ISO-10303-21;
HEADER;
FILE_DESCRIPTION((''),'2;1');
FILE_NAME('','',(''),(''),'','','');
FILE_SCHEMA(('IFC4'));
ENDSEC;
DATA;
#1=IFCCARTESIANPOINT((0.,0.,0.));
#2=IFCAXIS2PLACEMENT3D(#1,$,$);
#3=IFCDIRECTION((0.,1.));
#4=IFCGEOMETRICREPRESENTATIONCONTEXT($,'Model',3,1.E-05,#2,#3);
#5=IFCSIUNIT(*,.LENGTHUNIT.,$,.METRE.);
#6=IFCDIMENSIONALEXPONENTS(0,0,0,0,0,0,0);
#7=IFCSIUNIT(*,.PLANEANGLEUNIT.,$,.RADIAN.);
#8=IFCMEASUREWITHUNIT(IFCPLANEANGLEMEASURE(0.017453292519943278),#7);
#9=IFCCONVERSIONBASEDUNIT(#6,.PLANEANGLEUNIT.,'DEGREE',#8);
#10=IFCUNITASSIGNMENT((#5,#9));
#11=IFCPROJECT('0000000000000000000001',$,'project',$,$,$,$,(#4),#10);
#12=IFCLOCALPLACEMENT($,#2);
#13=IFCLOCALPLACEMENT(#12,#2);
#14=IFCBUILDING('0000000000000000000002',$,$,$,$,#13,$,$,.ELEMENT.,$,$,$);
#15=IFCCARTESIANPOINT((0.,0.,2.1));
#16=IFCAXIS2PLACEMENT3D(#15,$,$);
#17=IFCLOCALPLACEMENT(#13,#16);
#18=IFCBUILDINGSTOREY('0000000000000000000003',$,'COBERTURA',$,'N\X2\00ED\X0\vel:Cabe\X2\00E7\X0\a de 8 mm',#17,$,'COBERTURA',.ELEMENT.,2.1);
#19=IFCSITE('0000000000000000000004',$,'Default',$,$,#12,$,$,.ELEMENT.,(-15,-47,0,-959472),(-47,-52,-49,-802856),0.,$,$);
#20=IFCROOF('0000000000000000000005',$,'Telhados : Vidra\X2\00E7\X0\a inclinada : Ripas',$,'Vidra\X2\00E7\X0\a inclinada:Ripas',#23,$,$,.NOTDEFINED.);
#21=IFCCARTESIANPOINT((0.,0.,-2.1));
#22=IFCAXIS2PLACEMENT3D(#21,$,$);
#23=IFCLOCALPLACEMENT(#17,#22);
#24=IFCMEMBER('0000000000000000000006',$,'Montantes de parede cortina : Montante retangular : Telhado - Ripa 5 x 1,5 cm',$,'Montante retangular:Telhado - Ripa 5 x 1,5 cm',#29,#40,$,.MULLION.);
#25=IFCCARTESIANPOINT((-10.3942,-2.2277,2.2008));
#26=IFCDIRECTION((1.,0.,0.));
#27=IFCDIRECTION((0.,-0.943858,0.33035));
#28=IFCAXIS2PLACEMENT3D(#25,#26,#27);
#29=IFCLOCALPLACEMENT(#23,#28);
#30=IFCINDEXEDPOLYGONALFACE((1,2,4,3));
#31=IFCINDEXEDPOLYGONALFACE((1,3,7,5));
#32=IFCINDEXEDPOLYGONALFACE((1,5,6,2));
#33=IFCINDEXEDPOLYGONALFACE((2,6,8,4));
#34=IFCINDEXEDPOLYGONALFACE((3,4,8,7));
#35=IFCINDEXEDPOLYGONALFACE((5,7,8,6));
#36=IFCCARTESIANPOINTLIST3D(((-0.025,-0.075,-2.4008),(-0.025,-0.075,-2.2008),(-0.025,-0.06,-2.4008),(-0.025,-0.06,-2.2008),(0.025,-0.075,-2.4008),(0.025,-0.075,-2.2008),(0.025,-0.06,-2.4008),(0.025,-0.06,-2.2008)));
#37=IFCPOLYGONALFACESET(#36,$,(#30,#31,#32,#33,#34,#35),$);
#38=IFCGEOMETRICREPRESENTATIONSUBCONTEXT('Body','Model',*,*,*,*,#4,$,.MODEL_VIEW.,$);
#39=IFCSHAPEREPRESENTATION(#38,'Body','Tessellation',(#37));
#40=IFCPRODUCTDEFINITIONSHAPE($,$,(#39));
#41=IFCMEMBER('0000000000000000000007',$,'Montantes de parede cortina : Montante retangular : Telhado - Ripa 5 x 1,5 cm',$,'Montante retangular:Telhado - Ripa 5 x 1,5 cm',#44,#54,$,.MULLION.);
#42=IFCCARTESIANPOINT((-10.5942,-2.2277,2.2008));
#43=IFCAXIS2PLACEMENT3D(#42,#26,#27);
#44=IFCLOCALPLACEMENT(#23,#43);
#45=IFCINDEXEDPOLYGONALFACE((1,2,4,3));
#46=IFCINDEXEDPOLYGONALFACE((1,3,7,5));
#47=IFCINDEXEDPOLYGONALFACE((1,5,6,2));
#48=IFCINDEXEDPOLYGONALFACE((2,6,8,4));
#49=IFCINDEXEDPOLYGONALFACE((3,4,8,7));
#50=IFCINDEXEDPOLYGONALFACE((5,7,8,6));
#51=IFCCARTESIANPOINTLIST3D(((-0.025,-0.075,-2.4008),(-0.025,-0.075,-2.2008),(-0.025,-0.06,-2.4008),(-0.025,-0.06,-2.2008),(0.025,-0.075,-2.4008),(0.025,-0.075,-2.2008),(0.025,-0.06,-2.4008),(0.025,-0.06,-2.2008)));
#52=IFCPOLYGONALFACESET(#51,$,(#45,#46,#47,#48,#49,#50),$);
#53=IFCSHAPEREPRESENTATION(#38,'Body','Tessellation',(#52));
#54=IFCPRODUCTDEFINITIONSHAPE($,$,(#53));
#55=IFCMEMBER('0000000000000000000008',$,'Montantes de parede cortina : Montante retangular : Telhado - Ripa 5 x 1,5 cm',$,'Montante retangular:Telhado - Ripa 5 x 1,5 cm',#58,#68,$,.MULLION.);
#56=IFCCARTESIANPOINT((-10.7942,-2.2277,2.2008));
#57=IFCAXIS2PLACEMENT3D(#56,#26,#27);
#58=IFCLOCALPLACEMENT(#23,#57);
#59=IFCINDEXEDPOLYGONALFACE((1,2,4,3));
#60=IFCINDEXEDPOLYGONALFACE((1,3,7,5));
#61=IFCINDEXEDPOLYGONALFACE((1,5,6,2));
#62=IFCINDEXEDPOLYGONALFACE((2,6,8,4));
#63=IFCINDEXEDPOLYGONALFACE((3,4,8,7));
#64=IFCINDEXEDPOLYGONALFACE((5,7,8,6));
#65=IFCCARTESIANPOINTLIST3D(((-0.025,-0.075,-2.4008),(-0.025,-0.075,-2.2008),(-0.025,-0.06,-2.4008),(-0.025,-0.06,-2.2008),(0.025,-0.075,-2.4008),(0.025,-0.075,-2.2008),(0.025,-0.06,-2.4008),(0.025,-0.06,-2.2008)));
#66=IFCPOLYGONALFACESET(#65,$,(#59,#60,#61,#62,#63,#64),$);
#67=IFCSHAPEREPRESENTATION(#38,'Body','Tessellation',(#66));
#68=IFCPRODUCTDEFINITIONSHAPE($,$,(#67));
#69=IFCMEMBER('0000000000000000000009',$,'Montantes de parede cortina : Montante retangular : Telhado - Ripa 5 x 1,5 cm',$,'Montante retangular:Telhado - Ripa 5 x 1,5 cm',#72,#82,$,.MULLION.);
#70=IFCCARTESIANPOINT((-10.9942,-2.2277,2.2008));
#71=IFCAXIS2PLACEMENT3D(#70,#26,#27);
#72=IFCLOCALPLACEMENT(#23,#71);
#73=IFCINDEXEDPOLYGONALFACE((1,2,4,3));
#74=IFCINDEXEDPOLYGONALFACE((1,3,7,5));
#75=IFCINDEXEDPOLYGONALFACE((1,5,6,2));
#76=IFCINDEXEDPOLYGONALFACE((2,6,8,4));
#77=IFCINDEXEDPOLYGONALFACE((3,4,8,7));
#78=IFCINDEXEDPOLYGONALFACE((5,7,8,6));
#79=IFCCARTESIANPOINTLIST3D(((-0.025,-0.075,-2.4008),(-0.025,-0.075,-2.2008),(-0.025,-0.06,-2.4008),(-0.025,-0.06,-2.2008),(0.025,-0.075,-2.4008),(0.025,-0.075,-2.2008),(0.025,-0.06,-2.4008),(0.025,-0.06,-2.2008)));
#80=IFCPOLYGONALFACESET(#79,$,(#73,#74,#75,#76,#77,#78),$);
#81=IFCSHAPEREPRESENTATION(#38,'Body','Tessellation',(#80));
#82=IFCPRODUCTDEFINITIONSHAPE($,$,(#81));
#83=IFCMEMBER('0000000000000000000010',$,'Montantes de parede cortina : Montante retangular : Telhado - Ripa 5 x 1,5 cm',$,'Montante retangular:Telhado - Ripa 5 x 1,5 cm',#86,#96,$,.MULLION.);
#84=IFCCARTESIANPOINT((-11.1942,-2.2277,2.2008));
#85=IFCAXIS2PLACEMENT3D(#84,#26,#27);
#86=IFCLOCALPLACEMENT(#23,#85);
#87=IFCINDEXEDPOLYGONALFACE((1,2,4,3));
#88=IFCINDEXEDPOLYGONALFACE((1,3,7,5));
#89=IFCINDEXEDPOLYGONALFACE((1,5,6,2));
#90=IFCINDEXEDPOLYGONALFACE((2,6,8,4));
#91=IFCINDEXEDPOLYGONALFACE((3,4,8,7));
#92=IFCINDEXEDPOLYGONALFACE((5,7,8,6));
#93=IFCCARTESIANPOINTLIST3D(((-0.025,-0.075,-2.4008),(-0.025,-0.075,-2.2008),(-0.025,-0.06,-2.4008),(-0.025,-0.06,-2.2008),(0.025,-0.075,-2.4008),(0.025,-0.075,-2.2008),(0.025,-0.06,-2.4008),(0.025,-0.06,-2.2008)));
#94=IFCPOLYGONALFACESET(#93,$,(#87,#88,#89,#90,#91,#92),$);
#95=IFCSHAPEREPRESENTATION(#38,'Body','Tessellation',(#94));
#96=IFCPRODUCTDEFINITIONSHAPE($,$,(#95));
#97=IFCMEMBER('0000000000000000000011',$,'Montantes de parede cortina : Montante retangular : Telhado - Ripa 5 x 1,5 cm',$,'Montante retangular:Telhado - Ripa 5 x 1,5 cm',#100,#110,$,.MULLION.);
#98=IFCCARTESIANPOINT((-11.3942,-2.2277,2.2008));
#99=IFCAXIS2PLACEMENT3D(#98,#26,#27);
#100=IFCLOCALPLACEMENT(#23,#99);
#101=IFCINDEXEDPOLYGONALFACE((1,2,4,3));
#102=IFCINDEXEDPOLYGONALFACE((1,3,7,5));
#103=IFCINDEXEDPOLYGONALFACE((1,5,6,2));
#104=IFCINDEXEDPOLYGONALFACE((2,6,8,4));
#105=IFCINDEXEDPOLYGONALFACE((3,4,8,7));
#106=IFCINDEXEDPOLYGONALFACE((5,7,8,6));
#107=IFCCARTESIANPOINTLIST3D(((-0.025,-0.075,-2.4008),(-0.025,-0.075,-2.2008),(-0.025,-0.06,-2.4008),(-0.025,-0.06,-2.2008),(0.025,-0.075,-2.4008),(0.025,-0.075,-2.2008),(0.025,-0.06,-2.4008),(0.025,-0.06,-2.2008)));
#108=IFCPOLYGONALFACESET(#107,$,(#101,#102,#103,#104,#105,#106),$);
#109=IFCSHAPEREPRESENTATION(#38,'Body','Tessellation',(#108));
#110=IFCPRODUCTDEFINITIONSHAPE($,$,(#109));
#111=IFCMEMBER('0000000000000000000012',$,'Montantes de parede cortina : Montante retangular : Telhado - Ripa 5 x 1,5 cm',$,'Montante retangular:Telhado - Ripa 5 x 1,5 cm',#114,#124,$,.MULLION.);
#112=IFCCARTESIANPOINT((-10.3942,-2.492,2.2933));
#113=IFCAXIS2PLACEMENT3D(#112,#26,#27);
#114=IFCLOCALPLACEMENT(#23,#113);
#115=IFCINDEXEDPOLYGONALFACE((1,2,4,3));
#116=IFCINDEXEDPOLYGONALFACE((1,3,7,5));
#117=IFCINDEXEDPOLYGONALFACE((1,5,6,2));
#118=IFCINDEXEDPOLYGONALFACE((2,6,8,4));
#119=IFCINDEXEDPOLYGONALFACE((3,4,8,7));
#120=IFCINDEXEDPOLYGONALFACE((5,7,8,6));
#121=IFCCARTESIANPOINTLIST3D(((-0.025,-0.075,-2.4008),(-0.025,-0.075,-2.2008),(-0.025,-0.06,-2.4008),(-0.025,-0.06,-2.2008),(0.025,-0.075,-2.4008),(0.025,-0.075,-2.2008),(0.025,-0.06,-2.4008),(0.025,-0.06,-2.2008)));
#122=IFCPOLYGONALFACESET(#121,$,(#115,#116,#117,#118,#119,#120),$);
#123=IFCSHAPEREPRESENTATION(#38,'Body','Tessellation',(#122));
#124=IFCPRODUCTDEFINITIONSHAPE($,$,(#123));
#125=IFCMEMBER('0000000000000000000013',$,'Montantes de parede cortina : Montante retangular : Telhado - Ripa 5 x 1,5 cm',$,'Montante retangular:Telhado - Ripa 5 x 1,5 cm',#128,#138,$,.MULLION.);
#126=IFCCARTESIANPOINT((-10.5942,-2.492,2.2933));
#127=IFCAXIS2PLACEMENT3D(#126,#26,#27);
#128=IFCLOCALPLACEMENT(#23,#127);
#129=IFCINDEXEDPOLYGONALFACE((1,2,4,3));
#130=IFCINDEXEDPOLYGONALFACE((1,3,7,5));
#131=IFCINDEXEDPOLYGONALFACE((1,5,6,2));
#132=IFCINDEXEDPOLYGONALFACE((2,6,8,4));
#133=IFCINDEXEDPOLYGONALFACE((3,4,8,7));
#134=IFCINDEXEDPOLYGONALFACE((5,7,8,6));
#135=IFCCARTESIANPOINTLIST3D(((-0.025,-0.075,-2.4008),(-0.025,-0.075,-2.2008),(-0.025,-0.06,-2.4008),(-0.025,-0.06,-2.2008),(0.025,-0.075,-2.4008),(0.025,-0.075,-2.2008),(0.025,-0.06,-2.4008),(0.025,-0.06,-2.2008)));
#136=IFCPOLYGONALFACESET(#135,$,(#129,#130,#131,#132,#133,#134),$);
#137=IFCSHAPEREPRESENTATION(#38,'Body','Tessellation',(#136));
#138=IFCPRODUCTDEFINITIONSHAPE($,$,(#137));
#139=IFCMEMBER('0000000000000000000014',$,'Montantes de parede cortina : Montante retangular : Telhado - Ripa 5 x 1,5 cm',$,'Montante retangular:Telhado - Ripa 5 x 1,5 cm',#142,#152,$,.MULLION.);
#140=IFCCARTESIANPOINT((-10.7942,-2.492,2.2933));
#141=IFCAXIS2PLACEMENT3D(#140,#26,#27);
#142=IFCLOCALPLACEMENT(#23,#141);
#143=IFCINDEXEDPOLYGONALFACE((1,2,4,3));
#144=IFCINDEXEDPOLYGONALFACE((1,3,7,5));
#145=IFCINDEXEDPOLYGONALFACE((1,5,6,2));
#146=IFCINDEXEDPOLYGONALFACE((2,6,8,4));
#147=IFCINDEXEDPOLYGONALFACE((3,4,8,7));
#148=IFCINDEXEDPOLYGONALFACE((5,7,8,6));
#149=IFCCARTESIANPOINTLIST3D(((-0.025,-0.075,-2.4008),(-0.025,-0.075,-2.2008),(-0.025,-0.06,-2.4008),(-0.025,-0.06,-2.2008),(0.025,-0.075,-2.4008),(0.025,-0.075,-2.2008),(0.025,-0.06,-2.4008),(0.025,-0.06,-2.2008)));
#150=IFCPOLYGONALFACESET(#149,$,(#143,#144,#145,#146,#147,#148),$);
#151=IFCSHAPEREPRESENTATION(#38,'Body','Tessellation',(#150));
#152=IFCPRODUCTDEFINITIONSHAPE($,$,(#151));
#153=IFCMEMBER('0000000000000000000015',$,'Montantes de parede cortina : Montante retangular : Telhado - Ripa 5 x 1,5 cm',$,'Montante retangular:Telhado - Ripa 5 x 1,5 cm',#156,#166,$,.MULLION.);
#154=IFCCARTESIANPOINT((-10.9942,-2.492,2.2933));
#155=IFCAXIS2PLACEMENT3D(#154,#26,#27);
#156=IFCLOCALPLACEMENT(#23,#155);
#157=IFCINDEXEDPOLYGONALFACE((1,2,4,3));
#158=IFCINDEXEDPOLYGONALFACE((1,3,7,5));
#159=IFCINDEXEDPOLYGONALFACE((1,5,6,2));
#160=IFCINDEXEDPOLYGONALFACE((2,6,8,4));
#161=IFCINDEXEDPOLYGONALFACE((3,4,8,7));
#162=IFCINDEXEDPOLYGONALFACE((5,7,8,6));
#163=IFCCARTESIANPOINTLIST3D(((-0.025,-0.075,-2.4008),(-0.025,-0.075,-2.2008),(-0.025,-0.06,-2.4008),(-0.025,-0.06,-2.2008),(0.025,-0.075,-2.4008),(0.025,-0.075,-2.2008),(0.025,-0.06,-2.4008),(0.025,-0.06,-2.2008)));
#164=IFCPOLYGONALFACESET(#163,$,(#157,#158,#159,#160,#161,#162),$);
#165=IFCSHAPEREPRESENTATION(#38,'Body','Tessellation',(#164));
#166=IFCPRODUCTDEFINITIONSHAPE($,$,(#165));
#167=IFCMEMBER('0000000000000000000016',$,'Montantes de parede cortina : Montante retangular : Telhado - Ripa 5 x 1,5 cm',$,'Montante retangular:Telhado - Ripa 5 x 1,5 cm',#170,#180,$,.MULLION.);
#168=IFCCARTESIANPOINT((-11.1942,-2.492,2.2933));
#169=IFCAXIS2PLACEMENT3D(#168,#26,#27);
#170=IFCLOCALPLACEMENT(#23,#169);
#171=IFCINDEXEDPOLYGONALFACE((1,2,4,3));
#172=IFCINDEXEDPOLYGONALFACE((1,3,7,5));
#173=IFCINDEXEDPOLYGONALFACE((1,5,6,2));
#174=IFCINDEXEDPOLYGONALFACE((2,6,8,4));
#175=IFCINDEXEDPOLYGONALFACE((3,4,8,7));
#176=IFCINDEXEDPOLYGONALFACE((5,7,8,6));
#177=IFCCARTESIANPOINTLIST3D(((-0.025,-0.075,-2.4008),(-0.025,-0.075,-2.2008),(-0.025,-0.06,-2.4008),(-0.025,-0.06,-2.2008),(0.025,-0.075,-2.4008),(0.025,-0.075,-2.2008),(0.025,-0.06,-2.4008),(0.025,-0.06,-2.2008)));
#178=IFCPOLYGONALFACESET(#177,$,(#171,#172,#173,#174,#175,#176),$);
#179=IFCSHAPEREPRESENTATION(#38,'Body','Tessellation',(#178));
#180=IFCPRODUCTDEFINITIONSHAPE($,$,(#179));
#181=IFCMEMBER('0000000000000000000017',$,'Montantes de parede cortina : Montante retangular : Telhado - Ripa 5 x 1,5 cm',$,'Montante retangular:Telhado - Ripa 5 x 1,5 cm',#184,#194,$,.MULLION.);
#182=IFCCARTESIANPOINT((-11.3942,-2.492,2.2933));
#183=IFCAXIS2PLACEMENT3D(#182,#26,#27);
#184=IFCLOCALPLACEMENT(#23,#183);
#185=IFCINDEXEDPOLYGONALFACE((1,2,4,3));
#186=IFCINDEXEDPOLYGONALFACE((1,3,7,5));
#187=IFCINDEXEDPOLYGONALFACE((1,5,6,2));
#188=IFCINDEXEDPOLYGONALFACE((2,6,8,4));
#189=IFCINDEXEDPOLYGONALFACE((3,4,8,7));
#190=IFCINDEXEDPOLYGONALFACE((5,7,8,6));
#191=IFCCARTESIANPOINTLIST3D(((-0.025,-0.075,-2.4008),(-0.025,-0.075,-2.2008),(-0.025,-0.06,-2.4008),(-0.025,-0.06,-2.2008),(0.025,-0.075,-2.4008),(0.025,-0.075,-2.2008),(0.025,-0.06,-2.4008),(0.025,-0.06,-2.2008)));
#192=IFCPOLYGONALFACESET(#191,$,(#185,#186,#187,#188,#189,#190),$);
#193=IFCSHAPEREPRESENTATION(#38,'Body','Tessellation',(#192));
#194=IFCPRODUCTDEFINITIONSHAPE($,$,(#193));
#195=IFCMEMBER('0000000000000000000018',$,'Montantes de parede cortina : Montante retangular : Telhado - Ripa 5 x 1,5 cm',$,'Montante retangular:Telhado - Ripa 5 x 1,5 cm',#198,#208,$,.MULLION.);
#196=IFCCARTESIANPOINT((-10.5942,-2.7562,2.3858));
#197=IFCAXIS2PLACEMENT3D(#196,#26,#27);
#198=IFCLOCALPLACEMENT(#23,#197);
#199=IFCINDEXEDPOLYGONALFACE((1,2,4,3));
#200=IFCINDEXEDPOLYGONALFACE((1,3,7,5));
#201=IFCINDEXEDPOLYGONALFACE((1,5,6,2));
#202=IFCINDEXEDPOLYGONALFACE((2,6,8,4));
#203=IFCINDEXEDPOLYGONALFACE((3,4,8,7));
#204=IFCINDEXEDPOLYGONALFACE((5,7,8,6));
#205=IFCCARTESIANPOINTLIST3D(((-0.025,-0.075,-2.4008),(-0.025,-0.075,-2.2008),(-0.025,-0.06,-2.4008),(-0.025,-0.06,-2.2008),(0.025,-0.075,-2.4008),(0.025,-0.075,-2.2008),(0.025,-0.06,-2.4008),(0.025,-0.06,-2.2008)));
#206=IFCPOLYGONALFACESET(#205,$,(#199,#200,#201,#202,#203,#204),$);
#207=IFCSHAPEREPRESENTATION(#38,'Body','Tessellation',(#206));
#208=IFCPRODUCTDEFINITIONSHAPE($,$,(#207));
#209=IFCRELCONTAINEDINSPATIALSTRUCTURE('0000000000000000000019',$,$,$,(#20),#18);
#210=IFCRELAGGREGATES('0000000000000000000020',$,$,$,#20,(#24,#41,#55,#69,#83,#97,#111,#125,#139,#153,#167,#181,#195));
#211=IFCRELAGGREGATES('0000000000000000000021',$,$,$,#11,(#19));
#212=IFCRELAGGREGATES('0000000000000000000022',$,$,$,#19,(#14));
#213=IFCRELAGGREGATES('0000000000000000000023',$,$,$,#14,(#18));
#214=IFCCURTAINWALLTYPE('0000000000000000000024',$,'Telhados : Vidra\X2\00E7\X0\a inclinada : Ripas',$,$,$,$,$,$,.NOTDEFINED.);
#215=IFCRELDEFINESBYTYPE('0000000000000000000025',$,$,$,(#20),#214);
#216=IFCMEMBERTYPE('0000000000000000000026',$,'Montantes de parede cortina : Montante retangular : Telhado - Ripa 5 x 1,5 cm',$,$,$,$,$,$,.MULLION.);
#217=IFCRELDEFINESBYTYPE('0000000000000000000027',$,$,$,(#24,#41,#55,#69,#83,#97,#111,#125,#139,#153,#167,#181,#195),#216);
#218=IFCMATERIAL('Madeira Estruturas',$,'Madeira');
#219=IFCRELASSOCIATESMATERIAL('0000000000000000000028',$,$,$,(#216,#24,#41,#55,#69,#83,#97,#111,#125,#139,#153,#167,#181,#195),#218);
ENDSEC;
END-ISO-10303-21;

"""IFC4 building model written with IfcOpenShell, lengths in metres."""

from ifc_helpers import new_model, entity, si_unit, converted_unit, direction, frame, origin, place, context, subcontext, project, spatial, indexed_curve, outline, extrude, source, transform, mapped, material, type_object, type_shapes, element, aggregate, save


model = new_model("IFC4")

# Units and contexts
model_context = context("Model", 3, precision=1e-05, world=origin(), true_north=direction((0.0, 1.0)))
body_context = subcontext(model_context, "Body", "Model", "MODEL_VIEW")
ifc_project = project(units=[si_unit("LENGTHUNIT", "METRE"), converted_unit("PLANEANGLEUNIT", "DEGREE", entity("IfcPlaneAngleMeasure", 0.017453292519943278), si_unit("PLANEANGLEUNIT", "RADIAN"), dimensions=[0, 0, 0, 0, 0, 0, 0])], contexts=[model_context])

# Site, building, storey
site_placement = place(None, origin())
site = spatial("IfcSite", under=ifc_project, at=site_placement, Name="Default", CompositionType="ELEMENT", RefLatitude=(-15, -47, 0, -959472), RefLongitude=(-47, -52, -49, -802856), RefElevation=0.0)
building_placement = place(site_placement, origin())
building = spatial("IfcBuilding", under=site, at=building_placement, CompositionType="ELEMENT")
storey_placement = place(building_placement, frame((0.0, 0.0, 2.1)))
storey = spatial("IfcBuildingStorey", under=building, at=storey_placement, Name="COBERTURA", ObjectType="Nível:Cabeça de 8 mm", LongName="COBERTURA", CompositionType="ELEMENT", Elevation=2.1)

# Roof, members
curtain_wall_type = type_object("IfcCurtainWallType", Name="Telhados : Vidraça inclinada : Ripas", PredefinedType="NOTDEFINED")
roof_placement = place(storey_placement, frame((0.0, 0.0, -2.1)))
roof = element("IfcRoof", 1, at=roof_placement, inside=storey, type_object=curtain_wall_type, Name="Telhados : Vidraça inclinada : Ripas", ObjectType="Vidraça inclinada:Ripas", PredefinedType="NOTDEFINED")
ifc_material = material(Name="Madeira Estruturas", Category="Madeira")
member_type = type_object("IfcMemberType", Name="Montantes de parede cortina : Montante retangular : Telhado - Ripa 5 x 1,5 cm", PredefinedType="MULLION", material=ifc_material)
shared_shape = source(origin(), body_context, "Body", "SweptSolid", [
    extrude(outline(indexed_curve([(-0.025, -0.0075), (0.025, -0.0075), (0.025, 0.0075), (-0.025, 0.0075), (-0.025, -0.0075)], self_intersect=False)), frame((0.0, -0.0675, -2.4008), z_axis=(0.0, 0.0, 1.0), x_axis=(-1.0, 0.0, 0.0)), (0.0, 0.0, 1.0), 0.2),
])
type_shapes(member_type, [shared_shape])
member_1_placement = place(roof_placement, frame((-10.3942, -2.2277, 2.2008), z_axis=(1.0, 0.0, 0.0), x_axis=(0.0, -0.943858, 0.33035)))
member_1 = element("IfcMember", 2, at=member_1_placement, type_object=member_type, material=ifc_material, Name="Montantes de parede cortina : Montante retangular : Telhado - Ripa 5 x 1,5 cm", ObjectType="Montante retangular:Telhado - Ripa 5 x 1,5 cm", PredefinedType="MULLION", context=body_context, shape_type="MappedRepresentation", body=[
    mapped(shared_shape, transform((0.0, 0.0, 0.0), scale=1.0)),
])
member_2_placement = place(roof_placement, frame((-10.5942, -2.2277, 2.2008), z_axis=(1.0, 0.0, 0.0), x_axis=(0.0, -0.943858, 0.33035)))
member_2 = element("IfcMember", 3, at=member_2_placement, type_object=member_type, material=ifc_material, Name="Montantes de parede cortina : Montante retangular : Telhado - Ripa 5 x 1,5 cm", ObjectType="Montante retangular:Telhado - Ripa 5 x 1,5 cm", PredefinedType="MULLION", context=body_context, shape_type="MappedRepresentation", body=[
    mapped(shared_shape, transform((0.0, 0.0, 0.0), scale=1.0)),
])
member_3_placement = place(roof_placement, frame((-10.7942, -2.2277, 2.2008), z_axis=(1.0, 0.0, 0.0), x_axis=(0.0, -0.943858, 0.33035)))
member_3 = element("IfcMember", 4, at=member_3_placement, type_object=member_type, material=ifc_material, Name="Montantes de parede cortina : Montante retangular : Telhado - Ripa 5 x 1,5 cm", ObjectType="Montante retangular:Telhado - Ripa 5 x 1,5 cm", PredefinedType="MULLION", context=body_context, shape_type="MappedRepresentation", body=[
    mapped(shared_shape, transform((0.0, 0.0, 0.0), scale=1.0)),
])
member_4_placement = place(roof_placement, frame((-10.9942, -2.2277, 2.2008), z_axis=(1.0, 0.0, 0.0), x_axis=(0.0, -0.943858, 0.33035)))
member_4 = element("IfcMember", 5, at=member_4_placement, type_object=member_type, material=ifc_material, Name="Montantes de parede cortina : Montante retangular : Telhado - Ripa 5 x 1,5 cm", ObjectType="Montante retangular:Telhado - Ripa 5 x 1,5 cm", PredefinedType="MULLION", context=body_context, shape_type="MappedRepresentation", body=[
    mapped(shared_shape, transform((0.0, 0.0, 0.0), scale=1.0)),
])
member_5_placement = place(roof_placement, frame((-11.1942, -2.2277, 2.2008), z_axis=(1.0, 0.0, 0.0), x_axis=(0.0, -0.943858, 0.33035)))
member_5 = element("IfcMember", 6, at=member_5_placement, type_object=member_type, material=ifc_material, Name="Montantes de parede cortina : Montante retangular : Telhado - Ripa 5 x 1,5 cm", ObjectType="Montante retangular:Telhado - Ripa 5 x 1,5 cm", PredefinedType="MULLION", context=body_context, shape_type="MappedRepresentation", body=[
    mapped(shared_shape, transform((0.0, 0.0, 0.0), scale=1.0)),
])
member_6_placement = place(roof_placement, frame((-11.3942, -2.2277, 2.2008), z_axis=(1.0, 0.0, 0.0), x_axis=(0.0, -0.943858, 0.33035)))
member_6 = element("IfcMember", 7, at=member_6_placement, type_object=member_type, material=ifc_material, Name="Montantes de parede cortina : Montante retangular : Telhado - Ripa 5 x 1,5 cm", ObjectType="Montante retangular:Telhado - Ripa 5 x 1,5 cm", PredefinedType="MULLION", context=body_context, shape_type="MappedRepresentation", body=[
    mapped(shared_shape, transform((0.0, 0.0, 0.0), scale=1.0)),
])
member_7_placement = place(roof_placement, frame((-10.3942, -2.492, 2.2933), z_axis=(1.0, 0.0, 0.0), x_axis=(0.0, -0.943858, 0.33035)))
member_7 = element("IfcMember", 8, at=member_7_placement, type_object=member_type, material=ifc_material, Name="Montantes de parede cortina : Montante retangular : Telhado - Ripa 5 x 1,5 cm", ObjectType="Montante retangular:Telhado - Ripa 5 x 1,5 cm", PredefinedType="MULLION", context=body_context, shape_type="MappedRepresentation", body=[
    mapped(shared_shape, transform((0.0, 0.0, 0.0), scale=1.0)),
])
member_8_placement = place(roof_placement, frame((-10.5942, -2.492, 2.2933), z_axis=(1.0, 0.0, 0.0), x_axis=(0.0, -0.943858, 0.33035)))
member_8 = element("IfcMember", 9, at=member_8_placement, type_object=member_type, material=ifc_material, Name="Montantes de parede cortina : Montante retangular : Telhado - Ripa 5 x 1,5 cm", ObjectType="Montante retangular:Telhado - Ripa 5 x 1,5 cm", PredefinedType="MULLION", context=body_context, shape_type="MappedRepresentation", body=[
    mapped(shared_shape, transform((0.0, 0.0, 0.0), scale=1.0)),
])
member_9_placement = place(roof_placement, frame((-10.7942, -2.492, 2.2933), z_axis=(1.0, 0.0, 0.0), x_axis=(0.0, -0.943858, 0.33035)))
member_9 = element("IfcMember", 10, at=member_9_placement, type_object=member_type, material=ifc_material, Name="Montantes de parede cortina : Montante retangular : Telhado - Ripa 5 x 1,5 cm", ObjectType="Montante retangular:Telhado - Ripa 5 x 1,5 cm", PredefinedType="MULLION", context=body_context, shape_type="MappedRepresentation", body=[
    mapped(shared_shape, transform((0.0, 0.0, 0.0), scale=1.0)),
])
member_10_placement = place(roof_placement, frame((-10.9942, -2.492, 2.2933), z_axis=(1.0, 0.0, 0.0), x_axis=(0.0, -0.943858, 0.33035)))
member_10 = element("IfcMember", 11, at=member_10_placement, type_object=member_type, material=ifc_material, Name="Montantes de parede cortina : Montante retangular : Telhado - Ripa 5 x 1,5 cm", ObjectType="Montante retangular:Telhado - Ripa 5 x 1,5 cm", PredefinedType="MULLION", context=body_context, shape_type="MappedRepresentation", body=[
    mapped(shared_shape, transform((0.0, 0.0, 0.0), scale=1.0)),
])
member_11_placement = place(roof_placement, frame((-11.1942, -2.492, 2.2933), z_axis=(1.0, 0.0, 0.0), x_axis=(0.0, -0.943858, 0.33035)))
member_11 = element("IfcMember", 12, at=member_11_placement, type_object=member_type, material=ifc_material, Name="Montantes de parede cortina : Montante retangular : Telhado - Ripa 5 x 1,5 cm", ObjectType="Montante retangular:Telhado - Ripa 5 x 1,5 cm", PredefinedType="MULLION", context=body_context, shape_type="MappedRepresentation", body=[
    mapped(shared_shape, transform((0.0, 0.0, 0.0), scale=1.0)),
])
member_12_placement = place(roof_placement, frame((-11.3942, -2.492, 2.2933), z_axis=(1.0, 0.0, 0.0), x_axis=(0.0, -0.943858, 0.33035)))
member_12 = element("IfcMember", 13, at=member_12_placement, type_object=member_type, material=ifc_material, Name="Montantes de parede cortina : Montante retangular : Telhado - Ripa 5 x 1,5 cm", ObjectType="Montante retangular:Telhado - Ripa 5 x 1,5 cm", PredefinedType="MULLION", context=body_context, shape_type="MappedRepresentation", body=[
    mapped(shared_shape, transform((0.0, 0.0, 0.0), scale=1.0)),
])
member_13_placement = place(roof_placement, frame((-10.5942, -2.7562, 2.3858), z_axis=(1.0, 0.0, 0.0), x_axis=(0.0, -0.943858, 0.33035)))
member_13 = element("IfcMember", 14, at=member_13_placement, type_object=member_type, material=ifc_material, Name="Montantes de parede cortina : Montante retangular : Telhado - Ripa 5 x 1,5 cm", ObjectType="Montante retangular:Telhado - Ripa 5 x 1,5 cm", PredefinedType="MULLION", context=body_context, shape_type="MappedRepresentation", body=[
    mapped(shared_shape, transform((0.0, 0.0, 0.0), scale=1.0)),
])
aggregate(roof, [member_1, member_2, member_3, member_4, member_5, member_6, member_7, member_8, member_9, member_10, member_11, member_12, member_13])

save(model, "model.ifc")
